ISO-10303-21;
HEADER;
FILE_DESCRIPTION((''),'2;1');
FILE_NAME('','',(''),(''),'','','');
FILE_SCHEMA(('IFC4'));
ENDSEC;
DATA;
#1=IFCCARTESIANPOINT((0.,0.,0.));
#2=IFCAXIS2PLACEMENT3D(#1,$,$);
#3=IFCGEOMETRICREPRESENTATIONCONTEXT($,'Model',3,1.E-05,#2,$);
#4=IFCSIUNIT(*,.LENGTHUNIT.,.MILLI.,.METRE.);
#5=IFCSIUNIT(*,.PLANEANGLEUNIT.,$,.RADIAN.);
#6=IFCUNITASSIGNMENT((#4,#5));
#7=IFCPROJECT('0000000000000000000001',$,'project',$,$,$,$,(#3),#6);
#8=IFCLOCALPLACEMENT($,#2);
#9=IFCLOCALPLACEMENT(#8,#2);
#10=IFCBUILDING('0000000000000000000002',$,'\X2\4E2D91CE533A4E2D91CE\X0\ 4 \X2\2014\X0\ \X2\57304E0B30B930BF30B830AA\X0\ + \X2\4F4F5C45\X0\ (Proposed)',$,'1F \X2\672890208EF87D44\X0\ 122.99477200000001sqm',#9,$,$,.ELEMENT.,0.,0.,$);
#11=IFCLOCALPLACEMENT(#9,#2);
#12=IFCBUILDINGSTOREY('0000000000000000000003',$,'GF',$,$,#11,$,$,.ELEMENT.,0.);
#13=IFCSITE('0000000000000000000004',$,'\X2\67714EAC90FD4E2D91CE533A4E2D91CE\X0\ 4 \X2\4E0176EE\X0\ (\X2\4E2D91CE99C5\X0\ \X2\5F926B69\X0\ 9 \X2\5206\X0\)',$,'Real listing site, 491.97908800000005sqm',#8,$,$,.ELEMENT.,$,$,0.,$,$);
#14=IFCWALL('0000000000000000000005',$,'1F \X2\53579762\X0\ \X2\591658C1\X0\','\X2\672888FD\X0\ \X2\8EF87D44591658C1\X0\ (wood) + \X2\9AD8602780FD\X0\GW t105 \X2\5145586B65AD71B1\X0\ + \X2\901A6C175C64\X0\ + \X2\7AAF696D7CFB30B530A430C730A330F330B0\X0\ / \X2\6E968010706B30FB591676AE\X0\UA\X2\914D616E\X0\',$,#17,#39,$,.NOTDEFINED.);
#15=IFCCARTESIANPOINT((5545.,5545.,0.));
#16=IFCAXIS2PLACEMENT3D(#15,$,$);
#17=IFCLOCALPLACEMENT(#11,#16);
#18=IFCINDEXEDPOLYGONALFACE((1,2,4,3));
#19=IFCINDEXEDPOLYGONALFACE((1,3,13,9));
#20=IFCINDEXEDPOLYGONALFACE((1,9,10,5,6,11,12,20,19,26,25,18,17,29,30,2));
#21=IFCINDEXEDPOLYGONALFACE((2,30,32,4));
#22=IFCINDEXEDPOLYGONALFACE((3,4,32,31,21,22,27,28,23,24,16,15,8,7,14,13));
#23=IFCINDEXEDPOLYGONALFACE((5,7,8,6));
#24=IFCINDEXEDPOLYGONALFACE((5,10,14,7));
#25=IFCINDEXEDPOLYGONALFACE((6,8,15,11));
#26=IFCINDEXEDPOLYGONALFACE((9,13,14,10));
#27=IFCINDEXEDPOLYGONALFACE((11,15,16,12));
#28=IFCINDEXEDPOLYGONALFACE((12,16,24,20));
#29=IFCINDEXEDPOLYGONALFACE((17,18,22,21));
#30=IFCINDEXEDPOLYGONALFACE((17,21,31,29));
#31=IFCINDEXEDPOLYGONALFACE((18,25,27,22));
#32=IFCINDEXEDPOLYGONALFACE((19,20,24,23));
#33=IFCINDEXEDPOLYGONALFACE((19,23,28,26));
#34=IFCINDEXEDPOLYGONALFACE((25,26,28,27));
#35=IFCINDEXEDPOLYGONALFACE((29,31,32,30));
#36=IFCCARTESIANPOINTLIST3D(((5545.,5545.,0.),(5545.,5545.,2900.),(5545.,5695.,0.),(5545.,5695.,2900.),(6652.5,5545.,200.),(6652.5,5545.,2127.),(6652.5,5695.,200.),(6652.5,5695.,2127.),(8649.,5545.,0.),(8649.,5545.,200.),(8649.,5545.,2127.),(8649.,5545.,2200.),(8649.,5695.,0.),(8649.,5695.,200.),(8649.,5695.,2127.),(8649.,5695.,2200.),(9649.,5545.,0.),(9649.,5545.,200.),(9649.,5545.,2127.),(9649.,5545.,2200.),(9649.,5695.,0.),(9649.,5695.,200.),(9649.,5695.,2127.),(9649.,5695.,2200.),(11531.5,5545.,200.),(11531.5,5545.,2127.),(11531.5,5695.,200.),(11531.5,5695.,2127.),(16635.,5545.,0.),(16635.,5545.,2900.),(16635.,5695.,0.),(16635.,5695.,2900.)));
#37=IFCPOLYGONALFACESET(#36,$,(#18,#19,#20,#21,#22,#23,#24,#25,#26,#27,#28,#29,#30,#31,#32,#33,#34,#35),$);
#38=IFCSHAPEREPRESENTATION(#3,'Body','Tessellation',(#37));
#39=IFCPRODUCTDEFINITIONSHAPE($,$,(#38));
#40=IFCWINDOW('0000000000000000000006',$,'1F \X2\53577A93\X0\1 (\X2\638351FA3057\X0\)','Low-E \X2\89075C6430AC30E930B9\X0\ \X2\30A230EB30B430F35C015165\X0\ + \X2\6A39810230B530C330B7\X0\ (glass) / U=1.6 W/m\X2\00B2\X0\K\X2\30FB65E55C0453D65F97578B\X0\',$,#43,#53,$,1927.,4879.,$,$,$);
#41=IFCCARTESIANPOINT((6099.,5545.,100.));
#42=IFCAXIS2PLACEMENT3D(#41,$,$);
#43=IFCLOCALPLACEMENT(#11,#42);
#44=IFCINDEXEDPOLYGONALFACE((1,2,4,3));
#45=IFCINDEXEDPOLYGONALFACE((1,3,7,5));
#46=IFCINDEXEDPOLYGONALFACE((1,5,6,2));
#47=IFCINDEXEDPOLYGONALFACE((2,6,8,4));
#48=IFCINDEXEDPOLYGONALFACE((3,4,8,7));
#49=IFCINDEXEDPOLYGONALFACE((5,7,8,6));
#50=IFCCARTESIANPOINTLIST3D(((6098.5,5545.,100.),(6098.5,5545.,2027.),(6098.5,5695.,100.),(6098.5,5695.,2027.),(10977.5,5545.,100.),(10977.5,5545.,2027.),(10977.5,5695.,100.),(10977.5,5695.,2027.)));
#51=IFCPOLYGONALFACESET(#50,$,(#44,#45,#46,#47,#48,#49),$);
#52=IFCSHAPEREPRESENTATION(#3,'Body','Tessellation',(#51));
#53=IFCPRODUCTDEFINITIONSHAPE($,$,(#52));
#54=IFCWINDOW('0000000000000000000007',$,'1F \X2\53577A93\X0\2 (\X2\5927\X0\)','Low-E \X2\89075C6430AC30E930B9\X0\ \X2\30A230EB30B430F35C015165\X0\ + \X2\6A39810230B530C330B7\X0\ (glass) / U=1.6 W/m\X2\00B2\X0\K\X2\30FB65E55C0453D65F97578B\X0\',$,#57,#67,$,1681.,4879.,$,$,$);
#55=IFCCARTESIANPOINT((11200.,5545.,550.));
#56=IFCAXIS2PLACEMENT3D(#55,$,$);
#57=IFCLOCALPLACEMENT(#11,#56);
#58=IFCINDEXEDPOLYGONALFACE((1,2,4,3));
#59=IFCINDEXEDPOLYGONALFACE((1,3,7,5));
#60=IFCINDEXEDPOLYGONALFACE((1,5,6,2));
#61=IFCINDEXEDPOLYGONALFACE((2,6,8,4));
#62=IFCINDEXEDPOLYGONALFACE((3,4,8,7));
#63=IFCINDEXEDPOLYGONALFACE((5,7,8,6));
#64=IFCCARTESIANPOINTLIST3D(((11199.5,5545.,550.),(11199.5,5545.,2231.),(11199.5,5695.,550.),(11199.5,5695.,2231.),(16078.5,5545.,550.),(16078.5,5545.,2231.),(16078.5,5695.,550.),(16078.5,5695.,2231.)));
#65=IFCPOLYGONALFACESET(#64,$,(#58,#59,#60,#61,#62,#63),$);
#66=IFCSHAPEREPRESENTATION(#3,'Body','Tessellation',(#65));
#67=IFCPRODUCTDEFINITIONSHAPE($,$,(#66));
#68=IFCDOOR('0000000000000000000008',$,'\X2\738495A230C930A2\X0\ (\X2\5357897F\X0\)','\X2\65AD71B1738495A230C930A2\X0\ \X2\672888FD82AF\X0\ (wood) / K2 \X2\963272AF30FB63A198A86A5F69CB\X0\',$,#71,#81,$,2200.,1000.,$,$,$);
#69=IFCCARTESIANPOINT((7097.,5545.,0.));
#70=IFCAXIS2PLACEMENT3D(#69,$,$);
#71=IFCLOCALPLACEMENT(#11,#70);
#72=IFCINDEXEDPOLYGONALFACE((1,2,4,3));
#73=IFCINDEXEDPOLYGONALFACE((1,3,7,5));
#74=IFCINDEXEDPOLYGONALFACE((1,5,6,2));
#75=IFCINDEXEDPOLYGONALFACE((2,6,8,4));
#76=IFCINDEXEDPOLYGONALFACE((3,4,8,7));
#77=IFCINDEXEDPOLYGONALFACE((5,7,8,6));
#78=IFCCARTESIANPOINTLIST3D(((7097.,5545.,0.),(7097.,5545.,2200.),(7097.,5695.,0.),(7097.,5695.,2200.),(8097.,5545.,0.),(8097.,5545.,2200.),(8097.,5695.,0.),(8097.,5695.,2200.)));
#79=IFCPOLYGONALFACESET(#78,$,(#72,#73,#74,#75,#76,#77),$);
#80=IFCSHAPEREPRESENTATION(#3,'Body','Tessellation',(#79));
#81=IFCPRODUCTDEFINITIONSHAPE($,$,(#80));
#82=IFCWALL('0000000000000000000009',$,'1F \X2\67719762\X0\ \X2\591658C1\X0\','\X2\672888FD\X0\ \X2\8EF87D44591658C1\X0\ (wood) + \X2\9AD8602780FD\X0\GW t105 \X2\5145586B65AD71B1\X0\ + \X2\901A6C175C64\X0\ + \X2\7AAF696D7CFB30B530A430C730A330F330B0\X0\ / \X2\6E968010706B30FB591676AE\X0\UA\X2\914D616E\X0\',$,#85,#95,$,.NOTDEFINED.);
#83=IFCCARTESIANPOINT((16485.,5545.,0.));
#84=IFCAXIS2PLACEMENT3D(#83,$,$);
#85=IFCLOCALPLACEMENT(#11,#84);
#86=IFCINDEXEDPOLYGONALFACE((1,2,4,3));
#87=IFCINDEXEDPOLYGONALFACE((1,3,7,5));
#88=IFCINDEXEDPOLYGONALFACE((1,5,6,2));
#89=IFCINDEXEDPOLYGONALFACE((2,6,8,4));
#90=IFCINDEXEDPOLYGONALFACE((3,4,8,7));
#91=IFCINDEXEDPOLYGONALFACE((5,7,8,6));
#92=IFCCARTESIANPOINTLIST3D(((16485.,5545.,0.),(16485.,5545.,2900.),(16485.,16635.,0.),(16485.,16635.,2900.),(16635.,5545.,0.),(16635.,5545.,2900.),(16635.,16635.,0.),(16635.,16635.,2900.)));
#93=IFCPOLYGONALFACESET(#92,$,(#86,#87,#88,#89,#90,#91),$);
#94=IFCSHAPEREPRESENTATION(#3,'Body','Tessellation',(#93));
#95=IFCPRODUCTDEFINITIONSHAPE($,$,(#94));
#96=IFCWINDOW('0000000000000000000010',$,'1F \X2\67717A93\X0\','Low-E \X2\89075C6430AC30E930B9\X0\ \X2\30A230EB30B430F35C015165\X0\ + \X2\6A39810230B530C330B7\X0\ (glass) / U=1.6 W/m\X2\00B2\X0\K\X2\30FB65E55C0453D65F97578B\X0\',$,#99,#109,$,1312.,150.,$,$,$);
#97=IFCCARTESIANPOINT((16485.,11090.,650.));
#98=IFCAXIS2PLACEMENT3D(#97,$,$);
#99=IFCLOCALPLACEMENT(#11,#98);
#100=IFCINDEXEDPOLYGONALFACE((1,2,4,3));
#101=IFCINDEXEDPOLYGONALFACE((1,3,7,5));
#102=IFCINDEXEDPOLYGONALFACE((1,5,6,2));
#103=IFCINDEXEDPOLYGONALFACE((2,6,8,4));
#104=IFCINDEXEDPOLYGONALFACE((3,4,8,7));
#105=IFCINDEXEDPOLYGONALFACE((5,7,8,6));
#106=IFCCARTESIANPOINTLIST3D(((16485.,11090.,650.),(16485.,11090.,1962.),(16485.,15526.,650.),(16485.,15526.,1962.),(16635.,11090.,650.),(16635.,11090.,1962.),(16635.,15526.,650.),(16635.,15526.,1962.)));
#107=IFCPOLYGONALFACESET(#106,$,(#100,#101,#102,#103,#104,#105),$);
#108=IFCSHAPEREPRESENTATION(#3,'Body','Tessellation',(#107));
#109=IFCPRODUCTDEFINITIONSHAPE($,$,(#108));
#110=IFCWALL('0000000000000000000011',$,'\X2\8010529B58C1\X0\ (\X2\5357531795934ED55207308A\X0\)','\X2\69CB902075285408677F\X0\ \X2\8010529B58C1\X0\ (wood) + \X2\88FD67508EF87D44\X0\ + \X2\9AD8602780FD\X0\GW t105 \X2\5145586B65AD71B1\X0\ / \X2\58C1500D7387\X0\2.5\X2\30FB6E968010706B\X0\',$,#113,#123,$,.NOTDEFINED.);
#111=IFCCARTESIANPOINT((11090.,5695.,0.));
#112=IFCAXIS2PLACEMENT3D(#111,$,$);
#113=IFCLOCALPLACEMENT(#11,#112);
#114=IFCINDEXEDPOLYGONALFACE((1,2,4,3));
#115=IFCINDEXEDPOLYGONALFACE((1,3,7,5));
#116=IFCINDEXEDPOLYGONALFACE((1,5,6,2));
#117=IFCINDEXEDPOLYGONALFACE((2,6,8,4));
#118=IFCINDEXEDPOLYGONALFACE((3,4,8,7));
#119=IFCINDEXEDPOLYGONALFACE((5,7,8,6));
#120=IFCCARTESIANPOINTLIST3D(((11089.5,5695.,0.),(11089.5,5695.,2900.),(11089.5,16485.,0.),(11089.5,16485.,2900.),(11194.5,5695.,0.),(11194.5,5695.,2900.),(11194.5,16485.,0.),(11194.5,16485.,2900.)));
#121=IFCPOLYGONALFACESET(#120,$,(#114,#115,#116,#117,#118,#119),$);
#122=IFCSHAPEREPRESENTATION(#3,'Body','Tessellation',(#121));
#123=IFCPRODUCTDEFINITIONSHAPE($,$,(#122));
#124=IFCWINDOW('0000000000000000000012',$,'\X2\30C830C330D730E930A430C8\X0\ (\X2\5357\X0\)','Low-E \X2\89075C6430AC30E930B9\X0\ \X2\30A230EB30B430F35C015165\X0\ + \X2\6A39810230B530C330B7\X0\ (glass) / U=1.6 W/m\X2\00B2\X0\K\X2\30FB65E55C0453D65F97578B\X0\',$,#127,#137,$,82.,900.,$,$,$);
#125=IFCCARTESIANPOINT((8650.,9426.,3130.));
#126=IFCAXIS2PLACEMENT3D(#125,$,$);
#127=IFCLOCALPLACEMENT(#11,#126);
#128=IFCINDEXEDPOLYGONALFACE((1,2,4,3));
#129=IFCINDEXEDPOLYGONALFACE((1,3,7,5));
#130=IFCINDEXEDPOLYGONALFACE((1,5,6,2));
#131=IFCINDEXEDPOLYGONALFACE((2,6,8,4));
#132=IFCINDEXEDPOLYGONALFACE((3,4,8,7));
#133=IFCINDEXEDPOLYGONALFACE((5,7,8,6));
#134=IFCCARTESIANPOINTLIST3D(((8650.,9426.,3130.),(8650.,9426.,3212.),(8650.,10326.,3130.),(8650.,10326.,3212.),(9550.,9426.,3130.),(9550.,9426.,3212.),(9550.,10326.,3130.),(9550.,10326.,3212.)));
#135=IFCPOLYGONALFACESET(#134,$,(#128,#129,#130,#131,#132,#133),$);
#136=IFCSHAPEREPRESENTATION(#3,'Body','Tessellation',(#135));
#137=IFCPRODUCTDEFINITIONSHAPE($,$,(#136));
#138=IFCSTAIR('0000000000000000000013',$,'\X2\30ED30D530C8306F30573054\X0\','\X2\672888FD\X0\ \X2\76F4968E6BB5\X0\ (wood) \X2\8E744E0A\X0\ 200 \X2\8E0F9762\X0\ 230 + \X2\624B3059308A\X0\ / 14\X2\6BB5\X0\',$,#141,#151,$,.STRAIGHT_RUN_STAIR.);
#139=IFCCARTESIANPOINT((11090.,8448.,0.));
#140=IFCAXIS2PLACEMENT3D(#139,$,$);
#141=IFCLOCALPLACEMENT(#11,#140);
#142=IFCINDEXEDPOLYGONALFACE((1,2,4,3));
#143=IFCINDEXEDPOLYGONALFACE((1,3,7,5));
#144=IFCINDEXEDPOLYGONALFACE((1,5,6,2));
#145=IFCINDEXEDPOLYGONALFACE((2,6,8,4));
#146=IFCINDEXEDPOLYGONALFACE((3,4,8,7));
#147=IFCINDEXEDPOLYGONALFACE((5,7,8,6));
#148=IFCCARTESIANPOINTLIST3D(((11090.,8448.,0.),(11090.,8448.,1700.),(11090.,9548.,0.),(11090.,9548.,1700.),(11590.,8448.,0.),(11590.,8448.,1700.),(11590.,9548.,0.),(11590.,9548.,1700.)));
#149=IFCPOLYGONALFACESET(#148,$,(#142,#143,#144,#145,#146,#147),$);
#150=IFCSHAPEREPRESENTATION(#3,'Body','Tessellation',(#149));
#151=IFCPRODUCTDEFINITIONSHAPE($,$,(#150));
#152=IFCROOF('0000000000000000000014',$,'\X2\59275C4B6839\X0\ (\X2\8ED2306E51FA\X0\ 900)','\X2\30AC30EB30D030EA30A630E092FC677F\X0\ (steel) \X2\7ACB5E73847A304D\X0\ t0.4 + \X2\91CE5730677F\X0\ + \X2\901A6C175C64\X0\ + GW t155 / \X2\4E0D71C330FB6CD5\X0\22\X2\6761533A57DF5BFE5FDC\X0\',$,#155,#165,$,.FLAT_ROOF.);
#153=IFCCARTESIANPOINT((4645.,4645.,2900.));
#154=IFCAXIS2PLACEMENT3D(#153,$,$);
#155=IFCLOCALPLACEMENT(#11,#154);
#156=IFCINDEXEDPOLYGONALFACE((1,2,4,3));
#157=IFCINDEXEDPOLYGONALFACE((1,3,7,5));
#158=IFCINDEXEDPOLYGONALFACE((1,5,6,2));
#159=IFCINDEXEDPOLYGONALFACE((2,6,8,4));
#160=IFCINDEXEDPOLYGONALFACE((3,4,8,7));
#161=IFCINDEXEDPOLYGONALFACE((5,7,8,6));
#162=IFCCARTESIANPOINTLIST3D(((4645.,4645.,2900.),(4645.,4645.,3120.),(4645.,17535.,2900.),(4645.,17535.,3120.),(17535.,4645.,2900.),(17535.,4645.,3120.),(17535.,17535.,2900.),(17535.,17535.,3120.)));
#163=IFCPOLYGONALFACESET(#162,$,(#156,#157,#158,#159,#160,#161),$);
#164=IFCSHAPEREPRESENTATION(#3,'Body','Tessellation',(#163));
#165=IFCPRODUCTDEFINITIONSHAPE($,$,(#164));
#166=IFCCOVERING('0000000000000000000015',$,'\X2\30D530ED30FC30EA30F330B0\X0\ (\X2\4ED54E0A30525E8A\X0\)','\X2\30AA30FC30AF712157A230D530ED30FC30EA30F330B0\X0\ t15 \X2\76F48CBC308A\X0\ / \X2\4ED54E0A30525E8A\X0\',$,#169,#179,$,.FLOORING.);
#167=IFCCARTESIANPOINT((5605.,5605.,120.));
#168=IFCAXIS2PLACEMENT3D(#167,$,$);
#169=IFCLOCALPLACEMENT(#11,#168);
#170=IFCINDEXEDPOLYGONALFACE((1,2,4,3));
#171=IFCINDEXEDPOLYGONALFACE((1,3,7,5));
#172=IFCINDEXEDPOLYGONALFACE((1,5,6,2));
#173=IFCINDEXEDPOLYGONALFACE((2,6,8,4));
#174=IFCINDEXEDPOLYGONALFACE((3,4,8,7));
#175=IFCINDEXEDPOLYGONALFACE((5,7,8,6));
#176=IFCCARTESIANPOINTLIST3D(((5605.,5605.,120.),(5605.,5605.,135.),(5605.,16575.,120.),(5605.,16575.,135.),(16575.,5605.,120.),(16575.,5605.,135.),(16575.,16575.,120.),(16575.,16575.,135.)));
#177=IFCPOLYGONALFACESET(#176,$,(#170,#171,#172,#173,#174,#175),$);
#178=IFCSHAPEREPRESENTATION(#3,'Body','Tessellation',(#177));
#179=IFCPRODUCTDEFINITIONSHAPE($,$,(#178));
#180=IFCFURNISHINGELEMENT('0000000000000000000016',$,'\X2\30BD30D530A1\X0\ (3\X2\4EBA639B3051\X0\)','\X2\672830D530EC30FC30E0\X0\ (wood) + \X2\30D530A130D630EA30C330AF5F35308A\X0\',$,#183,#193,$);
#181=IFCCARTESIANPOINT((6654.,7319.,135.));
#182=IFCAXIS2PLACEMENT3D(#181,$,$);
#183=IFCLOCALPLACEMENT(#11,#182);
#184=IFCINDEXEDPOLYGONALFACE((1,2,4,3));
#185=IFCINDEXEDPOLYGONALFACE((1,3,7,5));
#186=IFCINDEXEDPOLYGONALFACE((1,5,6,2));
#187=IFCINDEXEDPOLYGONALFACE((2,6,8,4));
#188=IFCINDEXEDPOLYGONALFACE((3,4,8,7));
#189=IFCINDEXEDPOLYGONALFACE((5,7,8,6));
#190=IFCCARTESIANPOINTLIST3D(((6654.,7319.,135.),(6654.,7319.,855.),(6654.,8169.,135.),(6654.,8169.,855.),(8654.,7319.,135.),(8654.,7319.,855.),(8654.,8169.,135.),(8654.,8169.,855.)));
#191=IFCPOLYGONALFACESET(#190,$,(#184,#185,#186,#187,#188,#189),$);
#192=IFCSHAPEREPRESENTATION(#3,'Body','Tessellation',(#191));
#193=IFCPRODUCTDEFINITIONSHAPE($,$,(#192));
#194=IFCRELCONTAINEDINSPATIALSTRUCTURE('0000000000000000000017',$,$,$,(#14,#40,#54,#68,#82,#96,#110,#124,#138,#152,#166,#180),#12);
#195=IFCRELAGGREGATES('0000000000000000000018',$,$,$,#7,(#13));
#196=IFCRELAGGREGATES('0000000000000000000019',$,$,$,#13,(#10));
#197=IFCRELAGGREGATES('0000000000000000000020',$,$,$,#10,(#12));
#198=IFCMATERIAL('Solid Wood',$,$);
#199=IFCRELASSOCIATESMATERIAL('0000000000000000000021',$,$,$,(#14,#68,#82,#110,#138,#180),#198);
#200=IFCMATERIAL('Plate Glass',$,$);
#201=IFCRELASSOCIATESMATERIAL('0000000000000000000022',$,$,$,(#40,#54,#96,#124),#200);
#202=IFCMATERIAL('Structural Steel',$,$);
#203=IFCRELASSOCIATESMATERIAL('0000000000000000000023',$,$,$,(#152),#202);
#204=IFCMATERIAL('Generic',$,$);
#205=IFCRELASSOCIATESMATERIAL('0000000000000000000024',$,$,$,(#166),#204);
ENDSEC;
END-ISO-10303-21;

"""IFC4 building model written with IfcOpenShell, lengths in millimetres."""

from ifc_helpers import new_model, si_unit, frame, frame_2d, origin, place, context, project, spatial, rectangle, extrude, material, element, fill, save


model = new_model("IFC4")

# Units and contexts
model_context = context("Model", 3, precision=1e-05, world=origin())
ifc_project = project(units=[si_unit("LENGTHUNIT", "METRE", prefix="MILLI"), si_unit("PLANEANGLEUNIT", "RADIAN")], contexts=[model_context])

# Site, building, storey
site_placement = place(None, origin())
site = spatial("IfcSite", under=ifc_project, at=site_placement, Name="東京都中野区中野 4 丁目 (中野駅 徒歩 9 分)", ObjectType="Real listing site, 491.97908800000005sqm", CompositionType="ELEMENT", RefElevation=0.0)
building_placement = place(site_placement, origin())
building = spatial("IfcBuilding", under=site, at=building_placement, Name="中野区中野 4 — 地下スタジオ + 住居 (Proposed)", ObjectType="1F 木造軸組 122.99477200000001sqm", CompositionType="ELEMENT", ElevationOfRefHeight=0.0, ElevationOfTerrain=0.0)
storey_placement = place(building_placement, origin())
storey = spatial("IfcBuildingStorey", under=building, at=storey_placement, Name="GF", CompositionType="ELEMENT", Elevation=0.0)

# Shared definitions
ifc_material_1 = material(Name="Solid Wood")

# Wall, openings, windows, door
wall_1_placement = place(storey_placement, frame((5545.0, 5545.0, 0.0)))
wall_1 = element("IfcWall", 1, at=wall_1_placement, inside=storey, material=ifc_material_1, Name="1F 南面 外壁", Description="木製 軸組外壁 (wood) + 高性能GW t105 充填断熱 + 通気層 + 窯業系サイディング / 準耐火・外皮UA配慮", PredefinedType="NOTDEFINED", context=model_context, shape_type="SweptSolid", body=[
    extrude(rectangle(XDim=11090.0, YDim=150.0, at=frame_2d((5545.0, 75.0))), frame((5545.0, 5545.0, 0.0)), (0.0, 0.0, 1.0), 2900.0),
])
opening_1_placement = place(storey_placement, frame((6099.0, 5545.0, 100.0)))
opening_1 = element("IfcOpeningElement", 2, at=opening_1_placement, cuts=wall_1, PredefinedType="NOTDEFINED", context=model_context, shape_type="SweptSolid", body=[
    extrude(rectangle(XDim=4879.0, YDim=150.0, at=frame_2d((2439.0, 75.0))), frame((6099.0, 5545.0, 100.0)), (0.0, 0.0, 1.0), 1927.0),
])
opening_2_placement = place(storey_placement, frame((11200.0, 5545.0, 550.0)))
opening_2 = element("IfcOpeningElement", 3, at=opening_2_placement, cuts=wall_1, PredefinedType="NOTDEFINED", context=model_context, shape_type="SweptSolid", body=[
    extrude(rectangle(XDim=4879.0, YDim=150.0, at=frame_2d((2439.0, 75.0))), frame((11200.0, 5545.0, 550.0)), (0.0, 0.0, 1.0), 1681.0),
])
opening_3_placement = place(storey_placement, frame((7097.0, 5545.0, 0.0)))
opening_3 = element("IfcOpeningElement", 4, at=opening_3_placement, cuts=wall_1, PredefinedType="NOTDEFINED", context=model_context, shape_type="SweptSolid", body=[
    extrude(rectangle(XDim=1000.0, YDim=150.0, at=frame_2d((500.0, 75.0))), frame((7097.0, 5545.0, 0.0)), (0.0, 0.0, 1.0), 2200.0),
])
ifc_material_2 = material(Name="Plate Glass")
window_1_placement = place(storey_placement, frame((6099.0, 5545.0, 100.0)))
window_1 = element("IfcWindow", 5, at=window_1_placement, inside=storey, material=ifc_material_2, Name="1F 南窓1 (掃出し)", Description="Low-E 複層ガラス アルゴン封入 + 樹脂サッシ (glass) / U=1.6 W/m²K・日射取得型", OverallHeight=1927.0, OverallWidth=4879.0, context=model_context, shape_type="SweptSolid", body=[
    extrude(rectangle(XDim=4879.0, YDim=150.0, at=frame_2d((2439.0, 75.0))), frame((6099.0, 5545.0, 100.0)), (0.0, 0.0, 1.0), 1927.0),
])
fill(opening_1, window_1)
window_2_placement = place(storey_placement, frame((11200.0, 5545.0, 550.0)))
window_2 = element("IfcWindow", 6, at=window_2_placement, inside=storey, material=ifc_material_2, Name="1F 南窓2 (大)", Description="Low-E 複層ガラス アルゴン封入 + 樹脂サッシ (glass) / U=1.6 W/m²K・日射取得型", OverallHeight=1681.0, OverallWidth=4879.0, context=model_context, shape_type="SweptSolid", body=[
    extrude(rectangle(XDim=4879.0, YDim=150.0, at=frame_2d((2439.0, 75.0))), frame((11200.0, 5545.0, 550.0)), (0.0, 0.0, 1.0), 1681.0),
])
fill(opening_2, window_2)
door_placement = place(storey_placement, frame((7097.0, 5545.0, 0.0)))
door = element("IfcDoor", 7, at=door_placement, inside=storey, material=ifc_material_1, Name="玄関ドア (南西)", Description="断熱玄関ドア 木製芯 (wood) / K2 防犯・採風機構", OverallHeight=2200.0, OverallWidth=1000.0, context=model_context, shape_type="SweptSolid", body=[
    extrude(rectangle(XDim=1000.0, YDim=150.0, at=frame_2d((500.0, 75.0))), frame((7097.0, 5545.0, 0.0)), (0.0, 0.0, 1.0), 2200.0),
])
fill(opening_3, door)

# Wall, opening, window
wall_2_placement = place(storey_placement, frame((16485.0, 5545.0, 0.0)))
wall_2 = element("IfcWall", 8, at=wall_2_placement, inside=storey, material=ifc_material_1, Name="1F 東面 外壁", Description="木製 軸組外壁 (wood) + 高性能GW t105 充填断熱 + 通気層 + 窯業系サイディング / 準耐火・外皮UA配慮", PredefinedType="NOTDEFINED", context=model_context, shape_type="SweptSolid", body=[
    extrude(rectangle(XDim=150.0, YDim=11090.0, at=frame_2d((75.0, 5545.0))), frame((16485.0, 5545.0, 0.0)), (0.0, 0.0, 1.0), 2900.0),
])
opening_4_placement = place(storey_placement, frame((16485.0, 11090.0, 650.0)))
opening_4 = element("IfcOpeningElement", 9, at=opening_4_placement, cuts=wall_2, PredefinedType="NOTDEFINED", context=model_context, shape_type="SweptSolid", body=[
    extrude(rectangle(XDim=150.0, YDim=4436.0, at=frame_2d((75.0, 2218.0))), frame((16485.0, 11090.0, 650.0)), (0.0, 0.0, 1.0), 1312.0),
])
window_3_placement = place(storey_placement, frame((16485.0, 11090.0, 650.0)))
window_3 = element("IfcWindow", 10, at=window_3_placement, inside=storey, material=ifc_material_2, Name="1F 東窓", Description="Low-E 複層ガラス アルゴン封入 + 樹脂サッシ (glass) / U=1.6 W/m²K・日射取得型", OverallHeight=1312.0, OverallWidth=150.0, context=model_context, shape_type="SweptSolid", body=[
    extrude(rectangle(XDim=150.0, YDim=4436.0, at=frame_2d((75.0, 2218.0))), frame((16485.0, 11090.0, 650.0)), (0.0, 0.0, 1.0), 1312.0),
])
fill(opening_4, window_3)

# Wall
wall_3_placement = place(storey_placement, frame((11090.0, 5695.0, 0.0)))
element("IfcWall", 11, at=wall_3_placement, inside=storey, material=ifc_material_1, Name="耐力壁 (南北間仕切り)", Description="構造用合板 耐力壁 (wood) + 製材軸組 + 高性能GW t105 充填断熱 / 壁倍率2.5・準耐火", PredefinedType="NOTDEFINED", context=model_context, shape_type="SweptSolid", body=[
    extrude(rectangle(XDim=105.0, YDim=10790.0, at=frame_2d((52.0, 5395.0))), frame((11090.0, 5695.0, 0.0)), (0.0, 0.0, 1.0), 2900.0),
])

# Window
window_4_placement = place(storey_placement, frame((8650.0, 9426.0, 3130.0)))
element("IfcWindow", 12, at=window_4_placement, inside=storey, material=ifc_material_2, Name="トップライト (南)", Description="Low-E 複層ガラス アルゴン封入 + 樹脂サッシ (glass) / U=1.6 W/m²K・日射取得型", OverallHeight=82.0, OverallWidth=900.0, context=model_context, shape_type="SweptSolid", body=[
    extrude(rectangle(XDim=900.0, YDim=900.0, at=frame_2d((450.0, 450.0))), frame((8650.0, 9426.0, 3130.0)), (0.0, 0.0, 1.0), 82.0),
])

# Stair
stair_placement = place(storey_placement, frame((11090.0, 8448.0, 0.0)))
element("IfcStair", 13, at=stair_placement, inside=storey, material=ifc_material_1, Name="ロフトはしご", Description="木製 直階段 (wood) 蹴上 200 踏面 230 + 手すり / 14段", PredefinedType="STRAIGHT_RUN_STAIR", context=model_context, shape_type="SweptSolid", body=[
    extrude(rectangle(XDim=500.0, YDim=1100.0, at=frame_2d((250.0, 550.0))), frame((11090.0, 8448.0, 0.0)), (0.0, 0.0, 1.0), 1700.0),
])

# Roof
ifc_material_3 = material(Name="Structural Steel")
roof_placement = place(storey_placement, frame((4645.0, 4645.0, 2900.0)))
element("IfcRoof", 14, at=roof_placement, inside=storey, material=ifc_material_3, Name="大屋根 (軒の出 900)", Description="ガルバリウム鋼板 (steel) 立平葺き t0.4 + 野地板 + 通気層 + GW t155 / 不燃・法22条区域対応", PredefinedType="FLAT_ROOF", context=model_context, shape_type="SweptSolid", body=[
    extrude(rectangle(XDim=12890.0, YDim=12890.0, at=frame_2d((6445.0, 6445.0))), frame((4645.0, 4645.0, 2900.0)), (0.0, 0.0, 1.0), 220.0),
])

# Covering
ifc_material_4 = material(Name="Generic")
covering_placement = place(storey_placement, frame((5605.0, 5605.0, 120.0)))
element("IfcCovering", 15, at=covering_placement, inside=storey, material=ifc_material_4, Name="フローリング (仕上げ床)", Description="オーク無垢フローリング t15 直貼り / 仕上げ床", PredefinedType="FLOORING", context=model_context, shape_type="SweptSolid", body=[
    extrude(rectangle(XDim=10970.0, YDim=10970.0, at=frame_2d((5485.0, 5485.0))), frame((5605.0, 5605.0, 120.0)), (0.0, 0.0, 1.0), 15.0),
])

# Furnishing element
furnishing_1_placement = place(storey_placement, frame((6654.0, 7319.0, 135.0)))
element("IfcFurnishingElement", 16, at=furnishing_1_placement, inside=storey, material=ifc_material_1, Name="ソファ (3人掛け)", Description="木フレーム (wood) + ファブリック張り", context=model_context, shape_type="SweptSolid", body=[
    extrude(rectangle(XDim=2000.0, YDim=850.0, at=frame_2d((1000.0, 425.0))), frame((6654.0, 7319.0, 135.0)), (0.0, 0.0, 1.0), 720.0),
])

save(model, "model.ifc")
